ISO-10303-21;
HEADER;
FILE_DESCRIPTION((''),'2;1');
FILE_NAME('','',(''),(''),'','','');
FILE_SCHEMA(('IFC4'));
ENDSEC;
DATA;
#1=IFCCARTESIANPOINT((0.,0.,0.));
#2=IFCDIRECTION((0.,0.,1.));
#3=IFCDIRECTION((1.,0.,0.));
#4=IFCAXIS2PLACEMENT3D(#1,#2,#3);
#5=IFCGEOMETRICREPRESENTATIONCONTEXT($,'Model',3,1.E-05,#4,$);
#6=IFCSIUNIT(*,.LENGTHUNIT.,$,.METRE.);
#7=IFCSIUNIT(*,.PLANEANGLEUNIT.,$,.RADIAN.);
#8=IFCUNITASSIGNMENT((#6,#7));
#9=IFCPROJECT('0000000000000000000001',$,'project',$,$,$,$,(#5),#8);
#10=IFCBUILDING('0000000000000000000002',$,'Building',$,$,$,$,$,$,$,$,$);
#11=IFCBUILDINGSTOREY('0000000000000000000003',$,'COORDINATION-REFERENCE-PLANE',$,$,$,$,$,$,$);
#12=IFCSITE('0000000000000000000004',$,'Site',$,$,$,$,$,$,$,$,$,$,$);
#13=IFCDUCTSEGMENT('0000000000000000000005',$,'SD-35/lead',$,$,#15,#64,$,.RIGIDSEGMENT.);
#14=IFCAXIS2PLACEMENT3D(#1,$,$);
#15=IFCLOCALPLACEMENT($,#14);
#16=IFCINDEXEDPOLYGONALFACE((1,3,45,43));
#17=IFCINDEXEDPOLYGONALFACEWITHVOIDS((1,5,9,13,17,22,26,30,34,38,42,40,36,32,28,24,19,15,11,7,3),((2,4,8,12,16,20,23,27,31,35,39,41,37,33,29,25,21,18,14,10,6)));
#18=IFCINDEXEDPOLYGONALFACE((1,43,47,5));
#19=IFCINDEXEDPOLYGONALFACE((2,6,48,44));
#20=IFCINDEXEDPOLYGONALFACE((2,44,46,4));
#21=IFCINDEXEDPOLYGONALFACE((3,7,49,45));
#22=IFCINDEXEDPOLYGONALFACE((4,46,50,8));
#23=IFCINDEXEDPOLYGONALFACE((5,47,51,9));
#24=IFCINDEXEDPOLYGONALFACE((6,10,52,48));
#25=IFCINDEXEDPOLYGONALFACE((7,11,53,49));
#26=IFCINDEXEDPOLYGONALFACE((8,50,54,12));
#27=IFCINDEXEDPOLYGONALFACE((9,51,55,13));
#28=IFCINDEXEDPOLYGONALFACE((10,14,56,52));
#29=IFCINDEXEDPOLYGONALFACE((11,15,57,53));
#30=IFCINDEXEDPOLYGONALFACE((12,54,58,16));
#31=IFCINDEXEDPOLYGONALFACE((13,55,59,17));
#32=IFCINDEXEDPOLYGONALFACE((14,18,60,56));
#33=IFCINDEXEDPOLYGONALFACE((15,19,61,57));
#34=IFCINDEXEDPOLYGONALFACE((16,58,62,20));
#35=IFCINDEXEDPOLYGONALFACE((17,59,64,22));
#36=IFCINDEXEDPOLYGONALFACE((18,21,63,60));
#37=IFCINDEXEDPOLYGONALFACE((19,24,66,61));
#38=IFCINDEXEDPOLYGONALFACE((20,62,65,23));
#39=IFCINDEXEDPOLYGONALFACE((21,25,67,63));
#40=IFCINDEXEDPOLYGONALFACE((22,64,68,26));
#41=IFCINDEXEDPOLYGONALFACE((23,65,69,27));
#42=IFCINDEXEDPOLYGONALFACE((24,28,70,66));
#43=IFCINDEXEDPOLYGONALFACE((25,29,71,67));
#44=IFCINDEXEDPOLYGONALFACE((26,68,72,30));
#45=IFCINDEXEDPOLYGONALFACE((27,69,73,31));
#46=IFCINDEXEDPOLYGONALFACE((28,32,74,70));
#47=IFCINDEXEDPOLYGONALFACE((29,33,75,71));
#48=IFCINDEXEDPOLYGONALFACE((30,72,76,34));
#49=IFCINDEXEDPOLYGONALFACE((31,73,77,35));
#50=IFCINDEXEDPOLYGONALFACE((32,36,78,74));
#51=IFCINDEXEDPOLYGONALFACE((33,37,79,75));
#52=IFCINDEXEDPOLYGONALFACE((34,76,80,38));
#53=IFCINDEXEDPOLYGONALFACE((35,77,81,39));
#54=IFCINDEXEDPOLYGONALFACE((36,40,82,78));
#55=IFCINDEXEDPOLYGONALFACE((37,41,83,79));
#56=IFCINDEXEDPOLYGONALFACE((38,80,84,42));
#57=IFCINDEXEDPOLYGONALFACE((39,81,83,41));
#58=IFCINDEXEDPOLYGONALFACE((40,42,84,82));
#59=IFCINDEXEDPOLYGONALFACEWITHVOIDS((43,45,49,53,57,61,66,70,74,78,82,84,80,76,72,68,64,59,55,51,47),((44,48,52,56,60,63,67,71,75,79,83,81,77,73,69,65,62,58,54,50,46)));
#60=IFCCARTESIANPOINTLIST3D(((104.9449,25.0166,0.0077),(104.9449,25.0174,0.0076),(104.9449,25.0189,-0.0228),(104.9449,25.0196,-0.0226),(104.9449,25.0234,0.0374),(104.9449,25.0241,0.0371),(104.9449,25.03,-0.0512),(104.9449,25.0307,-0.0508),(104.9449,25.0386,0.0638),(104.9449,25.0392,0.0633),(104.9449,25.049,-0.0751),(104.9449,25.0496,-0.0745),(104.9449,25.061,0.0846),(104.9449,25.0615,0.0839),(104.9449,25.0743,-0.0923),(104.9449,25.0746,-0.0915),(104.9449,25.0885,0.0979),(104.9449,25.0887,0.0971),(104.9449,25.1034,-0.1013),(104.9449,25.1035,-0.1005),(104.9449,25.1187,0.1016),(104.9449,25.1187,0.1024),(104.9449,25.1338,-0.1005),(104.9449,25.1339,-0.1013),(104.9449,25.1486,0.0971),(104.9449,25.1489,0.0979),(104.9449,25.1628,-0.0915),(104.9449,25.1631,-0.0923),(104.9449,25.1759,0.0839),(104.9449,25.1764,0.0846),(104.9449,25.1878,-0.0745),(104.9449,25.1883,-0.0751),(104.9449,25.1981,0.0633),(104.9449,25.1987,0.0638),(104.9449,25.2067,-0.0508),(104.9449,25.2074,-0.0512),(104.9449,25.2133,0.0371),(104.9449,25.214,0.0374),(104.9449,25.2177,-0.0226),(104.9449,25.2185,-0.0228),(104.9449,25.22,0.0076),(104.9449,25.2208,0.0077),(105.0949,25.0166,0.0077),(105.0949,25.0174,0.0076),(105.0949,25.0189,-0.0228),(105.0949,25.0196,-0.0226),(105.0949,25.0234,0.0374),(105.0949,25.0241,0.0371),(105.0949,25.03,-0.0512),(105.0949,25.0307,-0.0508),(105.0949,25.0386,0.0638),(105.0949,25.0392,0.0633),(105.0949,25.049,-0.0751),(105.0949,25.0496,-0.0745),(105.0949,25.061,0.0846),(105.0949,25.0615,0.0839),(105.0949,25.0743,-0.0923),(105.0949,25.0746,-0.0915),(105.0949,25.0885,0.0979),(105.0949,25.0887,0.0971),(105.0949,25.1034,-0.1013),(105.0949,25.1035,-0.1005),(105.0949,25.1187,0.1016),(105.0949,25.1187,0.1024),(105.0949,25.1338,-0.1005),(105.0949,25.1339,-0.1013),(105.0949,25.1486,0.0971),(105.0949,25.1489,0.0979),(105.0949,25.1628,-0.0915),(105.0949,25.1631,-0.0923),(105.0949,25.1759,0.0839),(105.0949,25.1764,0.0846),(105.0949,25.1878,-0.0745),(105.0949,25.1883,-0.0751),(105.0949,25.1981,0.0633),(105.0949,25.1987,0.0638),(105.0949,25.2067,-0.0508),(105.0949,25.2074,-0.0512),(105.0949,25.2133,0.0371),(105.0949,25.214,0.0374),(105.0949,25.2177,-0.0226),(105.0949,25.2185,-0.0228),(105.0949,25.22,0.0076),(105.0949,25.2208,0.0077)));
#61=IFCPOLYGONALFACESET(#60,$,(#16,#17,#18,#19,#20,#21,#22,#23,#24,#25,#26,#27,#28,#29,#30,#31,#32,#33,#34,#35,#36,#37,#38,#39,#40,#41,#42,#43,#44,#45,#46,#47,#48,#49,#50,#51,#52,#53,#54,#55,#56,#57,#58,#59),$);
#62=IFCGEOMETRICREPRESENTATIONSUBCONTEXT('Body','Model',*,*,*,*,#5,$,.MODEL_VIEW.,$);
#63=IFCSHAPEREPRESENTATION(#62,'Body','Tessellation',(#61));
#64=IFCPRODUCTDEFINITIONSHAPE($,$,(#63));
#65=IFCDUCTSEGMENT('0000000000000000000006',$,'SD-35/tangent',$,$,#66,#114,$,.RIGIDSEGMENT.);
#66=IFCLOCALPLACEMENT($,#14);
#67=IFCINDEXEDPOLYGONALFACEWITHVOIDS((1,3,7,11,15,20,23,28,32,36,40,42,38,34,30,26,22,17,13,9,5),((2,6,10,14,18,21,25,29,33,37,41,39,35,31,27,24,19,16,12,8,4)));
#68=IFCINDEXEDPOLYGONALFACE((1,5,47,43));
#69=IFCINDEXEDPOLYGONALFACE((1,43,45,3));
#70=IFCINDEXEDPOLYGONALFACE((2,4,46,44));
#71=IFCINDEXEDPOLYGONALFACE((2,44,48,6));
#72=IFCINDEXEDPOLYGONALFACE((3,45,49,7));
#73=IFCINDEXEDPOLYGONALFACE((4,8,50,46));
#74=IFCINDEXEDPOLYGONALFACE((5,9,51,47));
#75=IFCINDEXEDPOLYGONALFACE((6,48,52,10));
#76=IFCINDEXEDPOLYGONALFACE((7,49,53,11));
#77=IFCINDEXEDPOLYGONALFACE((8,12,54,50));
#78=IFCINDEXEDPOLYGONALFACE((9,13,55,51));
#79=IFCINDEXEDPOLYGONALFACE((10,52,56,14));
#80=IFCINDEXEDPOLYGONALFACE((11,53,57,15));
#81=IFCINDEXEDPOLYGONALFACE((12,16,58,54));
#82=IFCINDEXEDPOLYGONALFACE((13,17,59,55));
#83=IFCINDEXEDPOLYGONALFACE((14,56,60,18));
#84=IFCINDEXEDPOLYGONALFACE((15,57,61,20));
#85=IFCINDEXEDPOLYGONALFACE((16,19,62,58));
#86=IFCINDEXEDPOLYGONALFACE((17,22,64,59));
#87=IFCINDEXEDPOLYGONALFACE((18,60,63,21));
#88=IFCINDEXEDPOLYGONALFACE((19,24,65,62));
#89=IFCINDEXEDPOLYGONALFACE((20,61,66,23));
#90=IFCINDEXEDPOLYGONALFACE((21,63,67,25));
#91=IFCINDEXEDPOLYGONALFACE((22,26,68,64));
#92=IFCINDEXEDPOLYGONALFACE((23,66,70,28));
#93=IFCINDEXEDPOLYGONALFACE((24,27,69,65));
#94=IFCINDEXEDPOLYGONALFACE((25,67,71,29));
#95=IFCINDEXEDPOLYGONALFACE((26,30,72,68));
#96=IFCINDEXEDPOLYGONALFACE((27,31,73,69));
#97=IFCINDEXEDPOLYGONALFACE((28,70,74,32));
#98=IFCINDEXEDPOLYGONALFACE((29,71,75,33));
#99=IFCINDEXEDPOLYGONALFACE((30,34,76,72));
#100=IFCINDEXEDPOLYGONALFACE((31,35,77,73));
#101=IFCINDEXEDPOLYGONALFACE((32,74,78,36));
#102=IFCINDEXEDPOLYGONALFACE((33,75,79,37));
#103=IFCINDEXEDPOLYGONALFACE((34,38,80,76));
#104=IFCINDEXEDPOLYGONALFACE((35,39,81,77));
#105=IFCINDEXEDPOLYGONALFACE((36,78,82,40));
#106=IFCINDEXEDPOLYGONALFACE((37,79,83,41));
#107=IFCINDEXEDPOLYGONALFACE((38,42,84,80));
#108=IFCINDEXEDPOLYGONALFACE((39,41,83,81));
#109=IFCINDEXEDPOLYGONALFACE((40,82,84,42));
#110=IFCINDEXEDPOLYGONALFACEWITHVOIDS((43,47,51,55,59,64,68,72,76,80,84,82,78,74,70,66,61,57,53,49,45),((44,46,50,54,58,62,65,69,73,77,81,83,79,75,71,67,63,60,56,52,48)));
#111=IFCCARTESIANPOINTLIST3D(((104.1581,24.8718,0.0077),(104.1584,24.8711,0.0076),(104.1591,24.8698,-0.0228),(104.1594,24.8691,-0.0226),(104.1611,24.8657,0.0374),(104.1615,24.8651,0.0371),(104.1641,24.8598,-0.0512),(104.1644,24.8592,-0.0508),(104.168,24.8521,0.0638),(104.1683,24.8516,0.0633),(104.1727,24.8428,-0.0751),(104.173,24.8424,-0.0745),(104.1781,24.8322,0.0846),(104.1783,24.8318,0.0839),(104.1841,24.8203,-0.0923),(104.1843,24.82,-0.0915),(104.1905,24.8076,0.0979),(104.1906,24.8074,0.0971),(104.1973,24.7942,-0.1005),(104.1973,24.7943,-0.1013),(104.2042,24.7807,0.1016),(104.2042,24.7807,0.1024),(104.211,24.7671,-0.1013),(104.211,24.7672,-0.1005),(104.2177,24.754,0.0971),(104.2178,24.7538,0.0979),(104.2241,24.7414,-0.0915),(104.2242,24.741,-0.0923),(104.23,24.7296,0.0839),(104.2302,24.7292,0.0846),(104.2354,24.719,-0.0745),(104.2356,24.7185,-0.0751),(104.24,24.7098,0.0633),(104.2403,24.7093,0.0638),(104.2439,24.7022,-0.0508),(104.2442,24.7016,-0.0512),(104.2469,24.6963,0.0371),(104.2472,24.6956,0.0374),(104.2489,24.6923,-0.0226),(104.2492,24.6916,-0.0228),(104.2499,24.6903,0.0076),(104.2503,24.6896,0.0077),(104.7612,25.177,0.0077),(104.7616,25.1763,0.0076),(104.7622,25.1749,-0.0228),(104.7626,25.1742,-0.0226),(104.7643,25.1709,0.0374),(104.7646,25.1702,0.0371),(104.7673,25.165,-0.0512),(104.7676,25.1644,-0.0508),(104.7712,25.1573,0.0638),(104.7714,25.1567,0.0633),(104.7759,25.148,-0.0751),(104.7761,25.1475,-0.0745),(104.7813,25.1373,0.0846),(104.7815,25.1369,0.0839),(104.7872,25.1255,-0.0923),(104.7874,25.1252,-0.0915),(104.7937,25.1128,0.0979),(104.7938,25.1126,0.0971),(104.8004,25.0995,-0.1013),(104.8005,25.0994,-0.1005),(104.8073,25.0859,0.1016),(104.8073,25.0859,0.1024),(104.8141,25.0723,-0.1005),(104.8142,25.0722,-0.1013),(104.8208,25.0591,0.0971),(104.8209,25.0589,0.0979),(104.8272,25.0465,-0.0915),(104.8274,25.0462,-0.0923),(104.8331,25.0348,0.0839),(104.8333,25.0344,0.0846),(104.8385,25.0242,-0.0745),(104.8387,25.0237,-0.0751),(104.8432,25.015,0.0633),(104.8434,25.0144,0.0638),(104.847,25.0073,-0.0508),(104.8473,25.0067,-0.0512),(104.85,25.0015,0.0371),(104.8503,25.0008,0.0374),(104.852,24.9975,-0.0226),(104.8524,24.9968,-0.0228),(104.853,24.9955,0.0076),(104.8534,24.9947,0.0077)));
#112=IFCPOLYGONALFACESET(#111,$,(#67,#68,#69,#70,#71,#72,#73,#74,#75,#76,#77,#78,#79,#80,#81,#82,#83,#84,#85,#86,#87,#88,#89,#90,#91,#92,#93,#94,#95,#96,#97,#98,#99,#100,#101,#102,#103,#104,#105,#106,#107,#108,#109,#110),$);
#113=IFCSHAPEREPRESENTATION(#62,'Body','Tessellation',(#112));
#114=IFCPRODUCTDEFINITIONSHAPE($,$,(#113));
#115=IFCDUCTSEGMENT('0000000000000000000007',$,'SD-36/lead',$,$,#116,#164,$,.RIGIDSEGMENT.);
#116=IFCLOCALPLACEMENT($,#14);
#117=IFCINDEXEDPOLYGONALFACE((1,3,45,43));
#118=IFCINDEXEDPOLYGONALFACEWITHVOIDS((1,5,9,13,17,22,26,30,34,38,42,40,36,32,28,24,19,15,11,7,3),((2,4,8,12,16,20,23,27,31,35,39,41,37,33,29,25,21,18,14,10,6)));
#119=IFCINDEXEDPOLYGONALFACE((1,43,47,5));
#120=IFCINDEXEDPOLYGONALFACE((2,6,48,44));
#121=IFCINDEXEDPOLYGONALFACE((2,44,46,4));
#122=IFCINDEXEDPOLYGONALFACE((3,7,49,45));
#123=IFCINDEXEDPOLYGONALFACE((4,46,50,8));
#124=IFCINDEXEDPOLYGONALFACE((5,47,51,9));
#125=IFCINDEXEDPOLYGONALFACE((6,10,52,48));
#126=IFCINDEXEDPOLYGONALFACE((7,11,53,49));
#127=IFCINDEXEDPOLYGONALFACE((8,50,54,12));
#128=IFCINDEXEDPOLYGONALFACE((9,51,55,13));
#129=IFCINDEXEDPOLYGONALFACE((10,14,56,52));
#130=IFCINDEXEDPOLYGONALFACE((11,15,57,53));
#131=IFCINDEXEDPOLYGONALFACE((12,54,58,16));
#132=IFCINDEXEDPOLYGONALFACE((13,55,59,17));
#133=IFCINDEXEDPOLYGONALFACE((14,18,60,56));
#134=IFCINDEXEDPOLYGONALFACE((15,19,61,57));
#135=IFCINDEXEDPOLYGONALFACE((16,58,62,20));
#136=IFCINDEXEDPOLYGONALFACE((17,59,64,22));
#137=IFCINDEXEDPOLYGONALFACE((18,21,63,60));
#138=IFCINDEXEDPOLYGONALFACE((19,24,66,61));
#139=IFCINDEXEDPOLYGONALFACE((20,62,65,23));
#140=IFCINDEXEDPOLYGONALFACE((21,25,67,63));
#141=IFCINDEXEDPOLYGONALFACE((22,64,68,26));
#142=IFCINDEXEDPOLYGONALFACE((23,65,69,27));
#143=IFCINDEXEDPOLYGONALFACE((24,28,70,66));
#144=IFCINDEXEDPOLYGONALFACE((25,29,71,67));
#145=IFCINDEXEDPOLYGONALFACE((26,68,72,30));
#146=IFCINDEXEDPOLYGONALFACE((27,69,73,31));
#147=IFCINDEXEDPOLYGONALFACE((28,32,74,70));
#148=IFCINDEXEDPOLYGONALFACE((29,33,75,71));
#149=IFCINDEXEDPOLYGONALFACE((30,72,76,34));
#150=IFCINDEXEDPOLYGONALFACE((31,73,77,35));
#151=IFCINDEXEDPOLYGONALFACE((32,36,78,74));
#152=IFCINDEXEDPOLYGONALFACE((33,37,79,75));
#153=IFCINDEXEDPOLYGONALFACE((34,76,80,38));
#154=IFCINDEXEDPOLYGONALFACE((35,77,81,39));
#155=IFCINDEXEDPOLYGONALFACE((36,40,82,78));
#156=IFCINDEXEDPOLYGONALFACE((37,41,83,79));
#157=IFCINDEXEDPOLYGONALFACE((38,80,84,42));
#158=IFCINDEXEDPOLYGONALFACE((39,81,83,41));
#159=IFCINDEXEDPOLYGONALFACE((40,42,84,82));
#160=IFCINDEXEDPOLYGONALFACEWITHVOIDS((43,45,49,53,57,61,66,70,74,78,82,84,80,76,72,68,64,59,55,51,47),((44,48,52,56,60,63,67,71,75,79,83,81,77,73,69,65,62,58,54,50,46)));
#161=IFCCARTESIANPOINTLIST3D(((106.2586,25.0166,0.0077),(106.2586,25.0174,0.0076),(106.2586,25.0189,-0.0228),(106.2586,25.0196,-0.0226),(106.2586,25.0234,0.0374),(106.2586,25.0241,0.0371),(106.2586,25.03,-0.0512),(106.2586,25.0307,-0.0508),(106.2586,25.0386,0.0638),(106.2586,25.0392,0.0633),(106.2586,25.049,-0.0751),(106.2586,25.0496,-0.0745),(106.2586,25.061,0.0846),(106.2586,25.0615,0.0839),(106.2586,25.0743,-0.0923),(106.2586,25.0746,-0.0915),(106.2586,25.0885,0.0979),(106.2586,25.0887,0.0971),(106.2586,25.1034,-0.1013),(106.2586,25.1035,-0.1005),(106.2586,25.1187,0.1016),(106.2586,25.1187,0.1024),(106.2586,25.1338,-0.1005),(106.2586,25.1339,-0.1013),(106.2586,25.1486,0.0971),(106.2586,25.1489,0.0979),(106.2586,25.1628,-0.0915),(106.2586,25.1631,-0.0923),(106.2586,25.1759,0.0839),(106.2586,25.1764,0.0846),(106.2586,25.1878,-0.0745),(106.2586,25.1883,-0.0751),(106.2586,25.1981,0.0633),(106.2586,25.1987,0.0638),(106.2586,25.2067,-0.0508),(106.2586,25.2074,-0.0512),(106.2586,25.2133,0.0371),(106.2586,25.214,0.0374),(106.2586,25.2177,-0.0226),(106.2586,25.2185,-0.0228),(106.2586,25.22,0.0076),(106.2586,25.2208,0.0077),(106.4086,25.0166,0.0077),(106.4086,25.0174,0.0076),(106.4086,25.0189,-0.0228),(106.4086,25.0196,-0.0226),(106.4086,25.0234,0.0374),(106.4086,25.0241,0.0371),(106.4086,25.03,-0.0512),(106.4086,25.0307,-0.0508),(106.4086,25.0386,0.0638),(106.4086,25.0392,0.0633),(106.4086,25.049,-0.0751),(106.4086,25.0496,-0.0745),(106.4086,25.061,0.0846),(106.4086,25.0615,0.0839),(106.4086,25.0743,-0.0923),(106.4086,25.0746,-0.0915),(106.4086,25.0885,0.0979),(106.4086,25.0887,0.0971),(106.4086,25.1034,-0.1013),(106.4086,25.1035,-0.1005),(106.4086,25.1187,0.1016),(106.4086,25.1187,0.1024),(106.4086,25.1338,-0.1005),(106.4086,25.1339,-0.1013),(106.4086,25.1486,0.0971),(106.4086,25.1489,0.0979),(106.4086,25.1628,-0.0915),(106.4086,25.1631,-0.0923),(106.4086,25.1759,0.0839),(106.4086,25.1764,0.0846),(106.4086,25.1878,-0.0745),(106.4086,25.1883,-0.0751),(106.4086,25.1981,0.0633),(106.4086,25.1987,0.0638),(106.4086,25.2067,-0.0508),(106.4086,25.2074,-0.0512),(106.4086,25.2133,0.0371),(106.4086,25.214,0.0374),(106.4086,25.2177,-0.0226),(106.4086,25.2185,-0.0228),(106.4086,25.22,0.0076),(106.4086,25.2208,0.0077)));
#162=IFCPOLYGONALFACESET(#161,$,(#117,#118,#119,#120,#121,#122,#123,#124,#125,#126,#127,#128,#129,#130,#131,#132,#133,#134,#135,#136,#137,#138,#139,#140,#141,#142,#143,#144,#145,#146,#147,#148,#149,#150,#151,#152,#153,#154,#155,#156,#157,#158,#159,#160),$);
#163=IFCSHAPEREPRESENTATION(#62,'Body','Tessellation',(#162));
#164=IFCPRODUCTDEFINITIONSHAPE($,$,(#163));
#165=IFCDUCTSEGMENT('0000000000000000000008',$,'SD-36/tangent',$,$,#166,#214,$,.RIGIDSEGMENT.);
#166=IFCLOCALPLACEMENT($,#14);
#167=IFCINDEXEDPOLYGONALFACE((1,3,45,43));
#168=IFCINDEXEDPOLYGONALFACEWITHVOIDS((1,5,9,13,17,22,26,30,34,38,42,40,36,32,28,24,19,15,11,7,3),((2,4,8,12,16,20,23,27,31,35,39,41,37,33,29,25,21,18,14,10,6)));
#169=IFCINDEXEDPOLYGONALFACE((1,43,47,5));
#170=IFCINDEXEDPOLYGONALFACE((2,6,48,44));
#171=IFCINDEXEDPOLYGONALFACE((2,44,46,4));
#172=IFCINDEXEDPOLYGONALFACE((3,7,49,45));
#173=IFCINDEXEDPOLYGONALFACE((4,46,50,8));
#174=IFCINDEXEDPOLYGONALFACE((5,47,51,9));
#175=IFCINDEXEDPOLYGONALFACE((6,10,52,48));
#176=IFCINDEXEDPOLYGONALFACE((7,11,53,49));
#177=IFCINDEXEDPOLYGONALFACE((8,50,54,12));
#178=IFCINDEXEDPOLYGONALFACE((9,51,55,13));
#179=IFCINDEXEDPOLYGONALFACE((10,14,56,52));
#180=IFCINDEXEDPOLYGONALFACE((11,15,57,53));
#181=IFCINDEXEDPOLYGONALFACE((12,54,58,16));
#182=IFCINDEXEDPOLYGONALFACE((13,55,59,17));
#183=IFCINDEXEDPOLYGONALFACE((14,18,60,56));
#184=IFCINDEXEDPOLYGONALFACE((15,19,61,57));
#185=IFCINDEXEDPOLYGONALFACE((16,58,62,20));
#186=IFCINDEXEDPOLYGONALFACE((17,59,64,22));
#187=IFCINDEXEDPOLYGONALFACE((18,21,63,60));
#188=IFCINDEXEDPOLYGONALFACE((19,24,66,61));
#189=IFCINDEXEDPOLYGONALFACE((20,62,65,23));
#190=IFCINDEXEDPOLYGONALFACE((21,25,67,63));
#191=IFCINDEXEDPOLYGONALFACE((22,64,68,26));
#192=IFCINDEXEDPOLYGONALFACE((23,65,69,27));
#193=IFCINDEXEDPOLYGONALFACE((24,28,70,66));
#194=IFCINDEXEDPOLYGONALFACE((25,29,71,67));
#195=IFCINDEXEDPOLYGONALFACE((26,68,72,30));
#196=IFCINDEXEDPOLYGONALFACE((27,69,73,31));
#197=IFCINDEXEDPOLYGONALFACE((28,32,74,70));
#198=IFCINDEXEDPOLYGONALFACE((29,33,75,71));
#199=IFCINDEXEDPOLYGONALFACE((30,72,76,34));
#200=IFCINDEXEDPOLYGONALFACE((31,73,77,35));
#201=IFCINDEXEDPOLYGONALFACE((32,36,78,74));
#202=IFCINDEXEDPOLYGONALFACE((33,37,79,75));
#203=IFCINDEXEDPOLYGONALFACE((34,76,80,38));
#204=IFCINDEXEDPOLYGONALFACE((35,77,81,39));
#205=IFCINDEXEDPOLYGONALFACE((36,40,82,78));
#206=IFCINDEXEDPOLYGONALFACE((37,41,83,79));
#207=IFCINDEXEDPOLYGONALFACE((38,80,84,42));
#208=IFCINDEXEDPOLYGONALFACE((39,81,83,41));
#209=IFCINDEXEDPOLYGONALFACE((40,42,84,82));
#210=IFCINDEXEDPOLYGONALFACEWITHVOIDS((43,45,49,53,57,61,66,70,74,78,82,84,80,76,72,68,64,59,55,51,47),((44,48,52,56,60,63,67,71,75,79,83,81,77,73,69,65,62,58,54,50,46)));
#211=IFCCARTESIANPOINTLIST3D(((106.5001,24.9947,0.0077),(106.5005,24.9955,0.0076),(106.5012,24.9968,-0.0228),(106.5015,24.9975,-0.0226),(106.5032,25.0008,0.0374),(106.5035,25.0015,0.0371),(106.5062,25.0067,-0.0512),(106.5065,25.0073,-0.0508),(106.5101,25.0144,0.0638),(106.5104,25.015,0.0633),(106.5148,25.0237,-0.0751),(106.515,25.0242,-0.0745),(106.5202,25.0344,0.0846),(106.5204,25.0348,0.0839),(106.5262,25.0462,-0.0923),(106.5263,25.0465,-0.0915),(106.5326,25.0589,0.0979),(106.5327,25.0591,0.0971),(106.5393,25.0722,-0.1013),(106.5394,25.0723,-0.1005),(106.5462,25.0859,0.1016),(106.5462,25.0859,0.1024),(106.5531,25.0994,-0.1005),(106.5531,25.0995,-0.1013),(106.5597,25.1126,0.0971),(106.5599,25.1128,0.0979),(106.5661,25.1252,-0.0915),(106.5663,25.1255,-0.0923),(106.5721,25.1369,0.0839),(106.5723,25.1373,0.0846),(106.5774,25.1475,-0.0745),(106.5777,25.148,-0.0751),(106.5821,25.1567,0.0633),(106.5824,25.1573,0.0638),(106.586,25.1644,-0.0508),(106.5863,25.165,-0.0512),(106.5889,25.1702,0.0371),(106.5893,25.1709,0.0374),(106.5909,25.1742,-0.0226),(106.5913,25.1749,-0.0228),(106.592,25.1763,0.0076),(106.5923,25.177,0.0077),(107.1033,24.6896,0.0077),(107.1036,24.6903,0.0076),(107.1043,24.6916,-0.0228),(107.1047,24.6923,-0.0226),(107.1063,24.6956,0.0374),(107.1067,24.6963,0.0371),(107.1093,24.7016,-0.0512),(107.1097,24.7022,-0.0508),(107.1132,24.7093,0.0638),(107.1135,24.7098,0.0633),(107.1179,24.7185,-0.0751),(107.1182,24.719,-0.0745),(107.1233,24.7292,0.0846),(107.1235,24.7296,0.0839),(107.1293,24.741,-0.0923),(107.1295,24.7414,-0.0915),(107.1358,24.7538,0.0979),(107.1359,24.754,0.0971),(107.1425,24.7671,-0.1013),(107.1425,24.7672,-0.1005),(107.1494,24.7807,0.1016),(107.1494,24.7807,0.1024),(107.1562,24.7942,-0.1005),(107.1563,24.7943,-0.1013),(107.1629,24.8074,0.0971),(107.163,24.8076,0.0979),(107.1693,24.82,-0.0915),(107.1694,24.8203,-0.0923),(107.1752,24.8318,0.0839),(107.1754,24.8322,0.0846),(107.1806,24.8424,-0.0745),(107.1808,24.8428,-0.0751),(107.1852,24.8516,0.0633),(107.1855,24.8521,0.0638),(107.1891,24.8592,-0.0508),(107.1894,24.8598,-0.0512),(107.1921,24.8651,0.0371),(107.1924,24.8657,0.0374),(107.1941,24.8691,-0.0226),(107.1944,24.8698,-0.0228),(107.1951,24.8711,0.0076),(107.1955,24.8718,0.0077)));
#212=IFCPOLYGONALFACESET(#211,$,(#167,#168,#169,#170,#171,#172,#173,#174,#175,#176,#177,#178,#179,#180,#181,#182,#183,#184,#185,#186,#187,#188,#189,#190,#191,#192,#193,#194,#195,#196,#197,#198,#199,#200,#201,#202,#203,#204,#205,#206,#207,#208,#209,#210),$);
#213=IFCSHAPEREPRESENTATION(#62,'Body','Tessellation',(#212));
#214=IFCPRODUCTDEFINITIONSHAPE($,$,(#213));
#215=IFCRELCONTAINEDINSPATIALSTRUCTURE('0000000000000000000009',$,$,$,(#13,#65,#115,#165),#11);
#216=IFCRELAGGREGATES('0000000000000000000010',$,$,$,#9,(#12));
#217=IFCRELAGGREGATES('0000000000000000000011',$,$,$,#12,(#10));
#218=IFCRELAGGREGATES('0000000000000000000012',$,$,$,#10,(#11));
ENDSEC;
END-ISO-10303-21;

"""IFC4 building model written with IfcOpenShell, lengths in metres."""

from ifc_helpers import new_model, si_unit, frame, origin_with_axes, place, context, subcontext, project, spatial, hollow_circle, extrude, element, save


model = new_model("IFC4")

# Units and contexts
model_context = context("Model", 3, precision=1e-05, world=origin_with_axes())
body_context_1 = subcontext(model_context, "Body", "Model", "MODEL_VIEW")
ifc_project = project(units=[si_unit("LENGTHUNIT", "METRE"), si_unit("PLANEANGLEUNIT", "RADIAN")], contexts=[model_context])

# Site, building, storey
site = spatial("IfcSite", under=ifc_project, Name="Site")
building = spatial("IfcBuilding", under=site, Name="Building")
storey = spatial("IfcBuildingStorey", under=building, Name="COORDINATION-REFERENCE-PLANE")

# Duct segment
duct_segment_1_placement = place(None, frame((105.0949, 25.1187, 0.0), z_axis=(-1.0, 0.0, 0.0), x_axis=(0.0, 0.0, 1.0)))
element("IfcDuctSegment", 1, at=duct_segment_1_placement, inside=storey, Name="SD-35/lead", PredefinedType="RIGIDSEGMENT", context=body_context_1, shape_type="SweptSolid", body=[
    extrude(hollow_circle(Radius=0.1024, WallThickness=0.0008), origin_with_axes(), (0.0, 0.0, 1.0), 0.15),
])

# Duct segment
duct_segment_2_placement = place(None, frame((104.8073, 25.0859, 0.0), z_axis=(-0.892292, -0.451458, 0.0), x_axis=(0.0, 0.0, 1.0)))
element("IfcDuctSegment", 2, at=duct_segment_2_placement, inside=storey, Name="SD-35/tangent", PredefinedType="RIGIDSEGMENT", context=body_context_1, shape_type="SweptSolid", body=[
    extrude(hollow_circle(Radius=0.1024, WallThickness=0.0008), origin_with_axes(), (0.0, 0.0, 1.0), 0.676),
])

# Duct segment
duct_segment_3_placement = place(None, frame((106.2586, 25.1187, 0.0), z_axis=(1.0, 0.0, 0.0), x_axis=(0.0, 0.0, 1.0)))
element("IfcDuctSegment", 3, at=duct_segment_3_placement, inside=storey, Name="SD-36/lead", PredefinedType="RIGIDSEGMENT", context=body_context_1, shape_type="SweptSolid", body=[
    extrude(hollow_circle(Radius=0.1024, WallThickness=0.0008), origin_with_axes(), (0.0, 0.0, 1.0), 0.15),
])

# Duct segment
duct_segment_4_placement = place(None, frame((106.5462, 25.0859, 0.0), z_axis=(0.892292, -0.451458, 0.0), x_axis=(0.0, 0.0, 1.0)))
element("IfcDuctSegment", 4, at=duct_segment_4_placement, inside=storey, Name="SD-36/tangent", PredefinedType="RIGIDSEGMENT", context=body_context_1, shape_type="SweptSolid", body=[
    extrude(hollow_circle(Radius=0.1024, WallThickness=0.0008), origin_with_axes(), (0.0, 0.0, 1.0), 0.676),
])

save(model, "model.ifc")
